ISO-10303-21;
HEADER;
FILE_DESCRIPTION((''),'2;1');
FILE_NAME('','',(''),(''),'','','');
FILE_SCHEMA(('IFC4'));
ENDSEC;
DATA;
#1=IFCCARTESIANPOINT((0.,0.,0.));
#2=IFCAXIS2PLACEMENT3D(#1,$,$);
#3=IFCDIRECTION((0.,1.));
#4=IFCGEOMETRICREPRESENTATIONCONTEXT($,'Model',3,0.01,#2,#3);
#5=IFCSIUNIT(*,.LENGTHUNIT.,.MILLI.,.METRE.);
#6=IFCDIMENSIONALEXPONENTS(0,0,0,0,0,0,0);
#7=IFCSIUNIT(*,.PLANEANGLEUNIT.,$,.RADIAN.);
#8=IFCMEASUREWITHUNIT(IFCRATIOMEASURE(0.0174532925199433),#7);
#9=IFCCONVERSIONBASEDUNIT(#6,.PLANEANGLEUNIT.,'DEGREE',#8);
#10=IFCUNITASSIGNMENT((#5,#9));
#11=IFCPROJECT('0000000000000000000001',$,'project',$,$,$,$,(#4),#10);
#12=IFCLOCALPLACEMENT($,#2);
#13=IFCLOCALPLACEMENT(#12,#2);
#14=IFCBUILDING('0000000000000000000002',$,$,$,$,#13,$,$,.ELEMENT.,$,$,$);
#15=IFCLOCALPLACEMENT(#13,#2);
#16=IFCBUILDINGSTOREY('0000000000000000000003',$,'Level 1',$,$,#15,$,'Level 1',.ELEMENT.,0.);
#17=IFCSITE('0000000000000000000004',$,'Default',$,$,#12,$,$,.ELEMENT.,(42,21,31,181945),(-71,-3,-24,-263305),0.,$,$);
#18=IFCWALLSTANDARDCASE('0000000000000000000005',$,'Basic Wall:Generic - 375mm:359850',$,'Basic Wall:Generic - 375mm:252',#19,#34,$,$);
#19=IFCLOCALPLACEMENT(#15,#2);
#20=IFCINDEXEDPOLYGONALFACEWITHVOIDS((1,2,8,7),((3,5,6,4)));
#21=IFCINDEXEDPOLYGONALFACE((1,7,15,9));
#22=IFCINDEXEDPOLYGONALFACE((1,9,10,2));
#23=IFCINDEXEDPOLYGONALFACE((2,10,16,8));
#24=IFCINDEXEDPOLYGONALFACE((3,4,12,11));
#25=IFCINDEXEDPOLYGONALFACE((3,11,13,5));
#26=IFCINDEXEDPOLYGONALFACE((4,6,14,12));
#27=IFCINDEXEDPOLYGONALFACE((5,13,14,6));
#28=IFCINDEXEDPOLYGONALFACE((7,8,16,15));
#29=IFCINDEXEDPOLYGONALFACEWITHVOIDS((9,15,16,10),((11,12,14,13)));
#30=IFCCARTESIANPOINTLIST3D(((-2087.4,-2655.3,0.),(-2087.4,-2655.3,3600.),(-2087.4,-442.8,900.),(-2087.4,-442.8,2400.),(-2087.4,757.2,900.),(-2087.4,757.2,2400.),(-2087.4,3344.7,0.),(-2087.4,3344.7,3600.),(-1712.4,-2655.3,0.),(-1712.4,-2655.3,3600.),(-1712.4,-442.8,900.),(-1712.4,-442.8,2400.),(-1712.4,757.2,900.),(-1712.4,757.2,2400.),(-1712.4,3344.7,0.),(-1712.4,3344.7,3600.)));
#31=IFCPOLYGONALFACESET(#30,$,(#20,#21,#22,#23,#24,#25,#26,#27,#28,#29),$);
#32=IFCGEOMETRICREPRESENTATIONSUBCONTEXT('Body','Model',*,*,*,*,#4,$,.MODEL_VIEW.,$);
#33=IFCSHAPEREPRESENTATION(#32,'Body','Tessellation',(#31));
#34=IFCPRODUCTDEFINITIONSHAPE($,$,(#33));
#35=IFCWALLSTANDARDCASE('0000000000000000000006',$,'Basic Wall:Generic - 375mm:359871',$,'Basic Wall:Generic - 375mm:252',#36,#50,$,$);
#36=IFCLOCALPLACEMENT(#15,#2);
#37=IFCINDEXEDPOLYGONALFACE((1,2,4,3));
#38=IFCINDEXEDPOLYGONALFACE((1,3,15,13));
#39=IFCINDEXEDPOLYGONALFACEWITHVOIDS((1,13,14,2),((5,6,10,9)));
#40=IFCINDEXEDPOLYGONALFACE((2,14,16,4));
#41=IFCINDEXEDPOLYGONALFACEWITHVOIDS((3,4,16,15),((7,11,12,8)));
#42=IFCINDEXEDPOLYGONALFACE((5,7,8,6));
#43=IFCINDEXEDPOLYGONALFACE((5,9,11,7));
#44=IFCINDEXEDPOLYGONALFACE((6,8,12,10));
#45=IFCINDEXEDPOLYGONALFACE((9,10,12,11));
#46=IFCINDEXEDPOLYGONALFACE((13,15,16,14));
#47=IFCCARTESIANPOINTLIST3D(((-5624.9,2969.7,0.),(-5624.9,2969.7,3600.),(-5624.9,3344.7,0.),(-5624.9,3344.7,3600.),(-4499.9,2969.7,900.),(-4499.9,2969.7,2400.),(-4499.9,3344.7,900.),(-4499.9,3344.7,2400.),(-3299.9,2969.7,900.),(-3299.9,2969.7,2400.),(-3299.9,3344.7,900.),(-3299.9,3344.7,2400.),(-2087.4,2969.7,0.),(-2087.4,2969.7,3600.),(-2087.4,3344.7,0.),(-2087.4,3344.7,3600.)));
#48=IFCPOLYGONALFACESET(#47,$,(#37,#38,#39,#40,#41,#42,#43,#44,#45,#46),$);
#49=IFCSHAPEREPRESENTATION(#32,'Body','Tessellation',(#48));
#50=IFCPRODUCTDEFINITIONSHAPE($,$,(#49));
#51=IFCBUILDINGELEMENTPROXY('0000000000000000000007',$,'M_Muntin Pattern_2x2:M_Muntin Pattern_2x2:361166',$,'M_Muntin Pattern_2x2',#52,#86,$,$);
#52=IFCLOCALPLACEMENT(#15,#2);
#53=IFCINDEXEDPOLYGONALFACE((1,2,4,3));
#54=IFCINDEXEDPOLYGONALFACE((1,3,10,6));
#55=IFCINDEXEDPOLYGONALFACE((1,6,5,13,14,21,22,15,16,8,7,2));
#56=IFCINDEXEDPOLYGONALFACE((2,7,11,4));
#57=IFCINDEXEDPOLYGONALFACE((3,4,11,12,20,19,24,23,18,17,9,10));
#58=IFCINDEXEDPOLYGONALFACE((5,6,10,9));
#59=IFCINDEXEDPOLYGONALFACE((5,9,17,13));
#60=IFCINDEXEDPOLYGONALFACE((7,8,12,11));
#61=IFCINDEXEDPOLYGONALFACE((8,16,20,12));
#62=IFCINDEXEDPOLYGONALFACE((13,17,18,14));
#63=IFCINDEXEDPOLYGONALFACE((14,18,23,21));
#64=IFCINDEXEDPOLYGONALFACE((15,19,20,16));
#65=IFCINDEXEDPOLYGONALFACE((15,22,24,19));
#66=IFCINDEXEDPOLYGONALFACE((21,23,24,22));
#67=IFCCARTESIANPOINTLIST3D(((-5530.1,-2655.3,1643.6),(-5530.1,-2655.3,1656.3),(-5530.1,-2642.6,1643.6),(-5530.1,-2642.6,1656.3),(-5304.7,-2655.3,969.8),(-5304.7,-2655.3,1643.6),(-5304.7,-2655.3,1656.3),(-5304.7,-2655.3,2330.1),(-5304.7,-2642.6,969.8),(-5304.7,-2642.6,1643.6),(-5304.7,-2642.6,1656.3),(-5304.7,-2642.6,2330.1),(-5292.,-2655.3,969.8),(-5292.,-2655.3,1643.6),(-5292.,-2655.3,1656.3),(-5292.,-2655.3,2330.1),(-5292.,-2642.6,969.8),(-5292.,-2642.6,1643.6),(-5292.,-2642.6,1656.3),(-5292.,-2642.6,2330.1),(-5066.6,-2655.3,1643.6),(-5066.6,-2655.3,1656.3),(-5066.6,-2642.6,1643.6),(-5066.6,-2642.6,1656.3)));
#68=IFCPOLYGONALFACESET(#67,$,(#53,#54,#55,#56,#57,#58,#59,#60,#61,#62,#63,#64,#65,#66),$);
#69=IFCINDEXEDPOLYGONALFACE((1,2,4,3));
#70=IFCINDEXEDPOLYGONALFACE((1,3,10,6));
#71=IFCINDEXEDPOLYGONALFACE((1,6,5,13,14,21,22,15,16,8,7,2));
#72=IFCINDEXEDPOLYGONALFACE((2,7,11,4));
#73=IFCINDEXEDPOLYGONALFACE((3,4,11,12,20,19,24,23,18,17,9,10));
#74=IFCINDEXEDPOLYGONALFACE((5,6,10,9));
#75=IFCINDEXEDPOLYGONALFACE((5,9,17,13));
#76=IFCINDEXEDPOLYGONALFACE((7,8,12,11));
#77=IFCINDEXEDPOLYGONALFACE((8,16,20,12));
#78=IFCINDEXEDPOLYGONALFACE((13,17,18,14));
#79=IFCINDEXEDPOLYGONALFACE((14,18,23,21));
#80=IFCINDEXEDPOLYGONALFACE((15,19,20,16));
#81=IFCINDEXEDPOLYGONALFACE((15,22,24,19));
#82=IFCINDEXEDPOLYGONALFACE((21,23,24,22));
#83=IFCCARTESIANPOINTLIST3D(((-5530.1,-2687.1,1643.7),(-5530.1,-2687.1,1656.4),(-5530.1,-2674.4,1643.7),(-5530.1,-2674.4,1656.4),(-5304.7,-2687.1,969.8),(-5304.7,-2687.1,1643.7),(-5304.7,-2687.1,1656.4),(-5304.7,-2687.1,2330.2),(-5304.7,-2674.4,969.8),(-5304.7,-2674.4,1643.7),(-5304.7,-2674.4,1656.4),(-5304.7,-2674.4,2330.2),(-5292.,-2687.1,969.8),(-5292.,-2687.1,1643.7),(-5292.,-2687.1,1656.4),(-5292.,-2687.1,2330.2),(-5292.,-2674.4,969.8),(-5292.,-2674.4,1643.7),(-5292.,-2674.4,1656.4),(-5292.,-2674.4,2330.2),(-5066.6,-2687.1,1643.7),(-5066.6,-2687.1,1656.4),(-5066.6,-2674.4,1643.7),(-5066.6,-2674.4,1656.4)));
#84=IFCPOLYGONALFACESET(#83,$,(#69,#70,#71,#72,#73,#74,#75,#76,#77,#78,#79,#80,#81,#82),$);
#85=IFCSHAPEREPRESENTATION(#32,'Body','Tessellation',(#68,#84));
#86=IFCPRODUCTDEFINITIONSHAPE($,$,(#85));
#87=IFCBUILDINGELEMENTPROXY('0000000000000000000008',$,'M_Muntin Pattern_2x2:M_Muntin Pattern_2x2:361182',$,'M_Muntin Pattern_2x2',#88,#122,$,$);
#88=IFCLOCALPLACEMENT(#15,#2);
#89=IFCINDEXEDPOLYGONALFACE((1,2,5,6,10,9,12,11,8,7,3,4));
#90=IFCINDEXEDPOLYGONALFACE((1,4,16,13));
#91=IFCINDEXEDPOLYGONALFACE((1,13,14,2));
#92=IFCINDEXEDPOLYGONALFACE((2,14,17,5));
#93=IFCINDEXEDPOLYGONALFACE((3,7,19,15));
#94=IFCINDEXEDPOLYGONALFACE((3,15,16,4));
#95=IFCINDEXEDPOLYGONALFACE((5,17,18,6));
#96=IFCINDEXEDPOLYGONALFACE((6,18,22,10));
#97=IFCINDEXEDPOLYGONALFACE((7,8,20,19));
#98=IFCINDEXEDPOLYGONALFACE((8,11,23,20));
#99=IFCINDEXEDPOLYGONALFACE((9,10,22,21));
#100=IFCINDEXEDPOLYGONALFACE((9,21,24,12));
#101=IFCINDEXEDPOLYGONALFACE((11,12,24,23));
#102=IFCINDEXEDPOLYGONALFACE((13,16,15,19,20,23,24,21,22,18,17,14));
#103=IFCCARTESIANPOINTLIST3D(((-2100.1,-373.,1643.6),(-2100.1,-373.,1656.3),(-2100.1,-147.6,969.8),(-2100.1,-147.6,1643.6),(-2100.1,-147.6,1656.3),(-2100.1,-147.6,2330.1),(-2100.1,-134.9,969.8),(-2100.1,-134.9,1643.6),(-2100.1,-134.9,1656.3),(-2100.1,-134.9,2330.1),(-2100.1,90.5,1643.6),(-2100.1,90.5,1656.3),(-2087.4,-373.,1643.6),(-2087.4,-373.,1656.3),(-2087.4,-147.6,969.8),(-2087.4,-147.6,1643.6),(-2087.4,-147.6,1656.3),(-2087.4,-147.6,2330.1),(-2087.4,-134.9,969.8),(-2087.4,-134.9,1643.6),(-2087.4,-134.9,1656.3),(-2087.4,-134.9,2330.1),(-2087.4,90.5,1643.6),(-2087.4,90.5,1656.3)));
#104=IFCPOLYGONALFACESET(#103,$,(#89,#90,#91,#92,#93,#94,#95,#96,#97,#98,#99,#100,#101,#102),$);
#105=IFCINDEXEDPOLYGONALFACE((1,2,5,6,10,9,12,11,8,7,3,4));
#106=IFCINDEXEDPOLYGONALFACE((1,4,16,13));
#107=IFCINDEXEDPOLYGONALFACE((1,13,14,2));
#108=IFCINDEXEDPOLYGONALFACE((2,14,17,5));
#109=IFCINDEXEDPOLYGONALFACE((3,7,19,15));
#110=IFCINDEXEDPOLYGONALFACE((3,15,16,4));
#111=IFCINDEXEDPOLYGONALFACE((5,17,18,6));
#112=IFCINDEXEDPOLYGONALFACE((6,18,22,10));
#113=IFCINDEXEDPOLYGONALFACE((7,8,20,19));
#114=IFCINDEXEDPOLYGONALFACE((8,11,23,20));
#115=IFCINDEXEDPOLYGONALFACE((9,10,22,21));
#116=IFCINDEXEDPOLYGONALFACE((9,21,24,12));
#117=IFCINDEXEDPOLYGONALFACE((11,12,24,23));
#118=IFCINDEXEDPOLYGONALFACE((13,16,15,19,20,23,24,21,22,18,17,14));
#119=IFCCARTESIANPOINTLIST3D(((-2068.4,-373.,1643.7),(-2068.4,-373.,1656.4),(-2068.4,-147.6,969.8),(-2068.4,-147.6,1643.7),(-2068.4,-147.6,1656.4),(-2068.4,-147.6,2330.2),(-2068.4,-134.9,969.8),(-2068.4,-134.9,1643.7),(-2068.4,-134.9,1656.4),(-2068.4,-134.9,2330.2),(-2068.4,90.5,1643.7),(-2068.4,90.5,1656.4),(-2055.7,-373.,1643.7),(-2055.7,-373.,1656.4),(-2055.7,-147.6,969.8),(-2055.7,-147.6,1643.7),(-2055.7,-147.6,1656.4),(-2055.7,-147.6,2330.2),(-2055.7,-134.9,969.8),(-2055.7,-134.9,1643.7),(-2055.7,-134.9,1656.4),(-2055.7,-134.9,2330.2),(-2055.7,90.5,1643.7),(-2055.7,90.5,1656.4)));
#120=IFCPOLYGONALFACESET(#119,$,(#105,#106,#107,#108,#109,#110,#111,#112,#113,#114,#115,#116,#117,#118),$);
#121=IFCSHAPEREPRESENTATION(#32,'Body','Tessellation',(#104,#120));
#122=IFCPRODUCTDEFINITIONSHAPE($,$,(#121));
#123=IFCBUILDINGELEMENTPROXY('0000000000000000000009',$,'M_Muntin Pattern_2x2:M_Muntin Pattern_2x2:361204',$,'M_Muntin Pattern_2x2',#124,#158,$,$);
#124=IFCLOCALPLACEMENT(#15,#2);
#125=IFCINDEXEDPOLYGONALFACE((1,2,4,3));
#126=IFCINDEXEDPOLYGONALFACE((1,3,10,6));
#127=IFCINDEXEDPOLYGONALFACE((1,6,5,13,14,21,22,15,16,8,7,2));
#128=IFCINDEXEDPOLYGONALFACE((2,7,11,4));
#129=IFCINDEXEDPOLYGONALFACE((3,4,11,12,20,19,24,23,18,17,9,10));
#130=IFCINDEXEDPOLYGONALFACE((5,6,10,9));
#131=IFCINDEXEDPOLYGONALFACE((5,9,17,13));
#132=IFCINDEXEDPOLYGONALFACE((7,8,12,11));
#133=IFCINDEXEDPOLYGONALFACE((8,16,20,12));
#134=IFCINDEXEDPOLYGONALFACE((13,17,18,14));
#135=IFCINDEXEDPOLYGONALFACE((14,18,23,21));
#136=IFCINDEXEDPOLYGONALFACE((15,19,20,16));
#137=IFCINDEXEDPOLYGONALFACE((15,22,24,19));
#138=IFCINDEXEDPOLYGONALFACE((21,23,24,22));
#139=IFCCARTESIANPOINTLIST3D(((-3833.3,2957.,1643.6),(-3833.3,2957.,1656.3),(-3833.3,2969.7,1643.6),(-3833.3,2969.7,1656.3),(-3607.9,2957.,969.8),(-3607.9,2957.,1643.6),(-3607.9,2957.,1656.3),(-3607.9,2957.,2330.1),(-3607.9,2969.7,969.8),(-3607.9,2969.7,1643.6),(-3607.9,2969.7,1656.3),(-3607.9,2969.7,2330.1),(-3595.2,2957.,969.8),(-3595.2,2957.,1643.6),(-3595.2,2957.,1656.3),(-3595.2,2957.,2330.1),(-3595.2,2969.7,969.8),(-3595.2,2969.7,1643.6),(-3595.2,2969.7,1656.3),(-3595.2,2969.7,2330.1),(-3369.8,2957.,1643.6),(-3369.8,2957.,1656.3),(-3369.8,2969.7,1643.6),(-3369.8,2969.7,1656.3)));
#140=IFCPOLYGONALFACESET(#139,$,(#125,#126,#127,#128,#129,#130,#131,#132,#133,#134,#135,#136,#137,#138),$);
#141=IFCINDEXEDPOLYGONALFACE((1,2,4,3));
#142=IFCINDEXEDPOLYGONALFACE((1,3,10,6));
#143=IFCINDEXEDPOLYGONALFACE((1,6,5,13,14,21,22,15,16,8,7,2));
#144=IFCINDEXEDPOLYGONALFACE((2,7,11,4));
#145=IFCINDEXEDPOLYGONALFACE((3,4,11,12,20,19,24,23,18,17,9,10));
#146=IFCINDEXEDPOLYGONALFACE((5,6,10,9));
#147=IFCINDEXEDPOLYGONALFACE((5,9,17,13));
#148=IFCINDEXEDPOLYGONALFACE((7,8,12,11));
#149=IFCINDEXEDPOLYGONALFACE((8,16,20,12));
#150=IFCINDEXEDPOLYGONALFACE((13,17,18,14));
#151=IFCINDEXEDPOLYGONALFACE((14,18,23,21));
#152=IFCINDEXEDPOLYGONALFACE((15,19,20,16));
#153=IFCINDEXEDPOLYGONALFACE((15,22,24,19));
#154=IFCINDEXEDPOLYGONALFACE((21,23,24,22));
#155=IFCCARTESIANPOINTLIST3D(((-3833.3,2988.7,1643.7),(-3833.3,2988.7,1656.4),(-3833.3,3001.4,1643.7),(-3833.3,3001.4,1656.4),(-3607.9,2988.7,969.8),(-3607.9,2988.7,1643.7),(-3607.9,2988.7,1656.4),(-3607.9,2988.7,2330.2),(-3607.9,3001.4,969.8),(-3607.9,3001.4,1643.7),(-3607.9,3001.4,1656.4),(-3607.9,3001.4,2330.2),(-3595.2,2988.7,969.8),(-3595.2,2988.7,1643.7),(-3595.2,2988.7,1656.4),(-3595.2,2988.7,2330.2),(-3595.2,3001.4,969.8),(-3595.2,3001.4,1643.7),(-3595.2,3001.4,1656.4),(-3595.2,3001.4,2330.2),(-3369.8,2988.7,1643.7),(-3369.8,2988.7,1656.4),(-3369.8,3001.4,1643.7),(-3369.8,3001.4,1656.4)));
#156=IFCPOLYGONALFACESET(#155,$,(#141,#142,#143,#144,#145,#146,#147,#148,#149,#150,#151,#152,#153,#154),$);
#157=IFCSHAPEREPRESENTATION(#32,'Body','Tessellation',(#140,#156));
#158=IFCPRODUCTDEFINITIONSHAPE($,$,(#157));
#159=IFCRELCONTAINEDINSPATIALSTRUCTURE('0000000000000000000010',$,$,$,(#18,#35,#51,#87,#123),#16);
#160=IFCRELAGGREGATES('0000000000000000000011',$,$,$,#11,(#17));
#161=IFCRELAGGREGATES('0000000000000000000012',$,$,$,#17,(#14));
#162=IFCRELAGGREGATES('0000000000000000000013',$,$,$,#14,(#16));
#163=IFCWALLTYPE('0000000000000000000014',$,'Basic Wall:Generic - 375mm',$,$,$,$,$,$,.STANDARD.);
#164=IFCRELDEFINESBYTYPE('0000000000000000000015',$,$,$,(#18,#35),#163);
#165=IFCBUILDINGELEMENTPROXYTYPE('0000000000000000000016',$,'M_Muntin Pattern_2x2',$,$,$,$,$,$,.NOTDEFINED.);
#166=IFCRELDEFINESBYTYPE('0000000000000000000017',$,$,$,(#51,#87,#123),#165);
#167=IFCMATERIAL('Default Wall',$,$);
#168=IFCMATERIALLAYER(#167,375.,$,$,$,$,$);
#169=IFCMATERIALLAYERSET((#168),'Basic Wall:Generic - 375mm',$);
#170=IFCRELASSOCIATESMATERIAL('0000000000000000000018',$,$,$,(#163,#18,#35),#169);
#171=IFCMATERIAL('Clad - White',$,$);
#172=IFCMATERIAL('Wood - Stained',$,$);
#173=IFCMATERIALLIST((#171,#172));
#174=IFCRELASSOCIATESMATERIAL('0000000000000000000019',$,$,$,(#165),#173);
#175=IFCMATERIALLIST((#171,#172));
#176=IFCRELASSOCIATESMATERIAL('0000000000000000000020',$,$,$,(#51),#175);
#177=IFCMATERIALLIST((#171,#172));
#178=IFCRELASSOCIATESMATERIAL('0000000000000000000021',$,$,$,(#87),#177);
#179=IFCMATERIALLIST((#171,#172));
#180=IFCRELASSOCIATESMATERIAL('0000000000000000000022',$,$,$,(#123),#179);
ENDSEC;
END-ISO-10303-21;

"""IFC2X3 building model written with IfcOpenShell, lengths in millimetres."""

from ifc_helpers import new_model, entity, si_unit, converted_unit, direction, frame, frame_2d, origin, place, context, subcontext, project, spatial, polyline, rectangle, outline, extrude, clip, bounded_halfspace, source, transform, mapped, material, material_list, layer, layer_set, layer_usage, type_object, type_shapes, element, save


model = new_model("IFC2X3")

# Units and contexts
model_context = context("Model", 3, precision=0.01, world=origin(), true_north=direction((0.0, 1.0)))
body_context = subcontext(model_context, "Body", "Model", "MODEL_VIEW")
ifc_project = project(units=[si_unit("LENGTHUNIT", "METRE", prefix="MILLI"), converted_unit("PLANEANGLEUNIT", "DEGREE", entity("IfcRatioMeasure", 0.0174532925199433), si_unit("PLANEANGLEUNIT", "RADIAN"), dimensions=[0, 0, 0, 0, 0, 0, 0])], contexts=[model_context])

# Site, building, storey
site_placement = place(None, origin())
site = spatial("IfcSite", under=ifc_project, at=site_placement, Name="Default", CompositionType="ELEMENT", RefLatitude=(42, 21, 31, 181945), RefLongitude=(-71, -3, -24, -263305), RefElevation=0.0)
building_placement = place(site_placement, origin())
building = spatial("IfcBuilding", under=site, at=building_placement, CompositionType="ELEMENT")
storey_placement = place(building_placement, origin())
storey = spatial("IfcBuildingStorey", under=building, at=storey_placement, Name="Level 1", LongName="Level 1", CompositionType="ELEMENT", Elevation=0.0)

# Walls, openings
ifc_material_1 = material(Name="Default Wall")
ifc_layer = layer(ifc_material_1, 375.0)
ifc_layer_set = layer_set([ifc_layer], Name="Basic Wall:Generic - 375mm")
ifc_layer_usage_1 = layer_usage(ifc_layer_set, "AXIS2", "NEGATIVE", 187.5)
wall_type = type_object("IfcWallType", Name="Basic Wall:Generic - 375mm", PredefinedType="STANDARD", material=ifc_layer_set)
wall_1_placement = place(storey_placement, frame((-1899.9, -2655.3, 0.0), z_axis=(0.0, 0.0, 1.0), x_axis=(0.0, 1.0, 0.0)))
wall_1 = element("IfcWallStandardCase", 1, at=wall_1_placement, inside=storey, type_object=wall_type, material=ifc_layer_usage_1, Name="Basic Wall:Generic - 375mm:359850", ObjectType="Basic Wall:Generic - 375mm:252", context=body_context, shape_type="Clipping", body=[
    clip(extrude(rectangle(XDim=6000.0, YDim=375.0, at=frame_2d((3000.0, 0.0), x_axis=(-1.0, 0.0))), origin(), (0.0, 0.0, 1.0), 3600.0), bounded_halfspace(frame((0.0, -187.5, 3600.0), z_axis=(0.0, 0.0, -1.0), x_axis=(0.0, -1.0, 0.0)), True, frame((0.0, -187.5, 3600.0)), polyline([(0.0, 0.0), (6000.0, 0.0), (6000.0, 375.0), (5625.0, 375.0), (0.0, 375.0), (0.0, 0.0)]))),
])
opening_1_placement = place(wall_1_placement, frame((2212.5, -187.5, 900.0)))
element("IfcOpeningElement", 2, at=opening_1_placement, cuts=wall_1, ObjectType="Opening", context=body_context, shape_type="SweptSolid", body=[
    extrude(rectangle(XDim=1500.0, YDim=1200.0, at=frame_2d((750.0, 600.0), x_axis=(-1.0, 0.0))), frame((0.0, 0.0, 0.0), z_axis=(0.0, 1.0, 0.0), x_axis=(0.0, 0.0, 1.0)), (0.0, 0.0, 1.0), 375.0),
])
ifc_layer_usage_2 = layer_usage(ifc_layer_set, "AXIS2", "NEGATIVE", 187.5)
wall_2_placement = place(storey_placement, frame((-2087.4, 3157.2, 0.0), z_axis=(0.0, 0.0, 1.0), x_axis=(-1.0, 0.0, 0.0)))
wall_2 = element("IfcWallStandardCase", 3, at=wall_2_placement, inside=storey, type_object=wall_type, material=ifc_layer_usage_2, Name="Basic Wall:Generic - 375mm:359871", ObjectType="Basic Wall:Generic - 375mm:252", context=body_context, shape_type="Clipping", body=[
    clip(extrude(rectangle(XDim=3537.5, YDim=375.0, at=frame_2d((1768.8, 0.0), x_axis=(-1.0, 0.0))), origin(), (0.0, 0.0, 1.0), 3600.0), bounded_halfspace(frame((0.0, -187.5, 3600.0), z_axis=(0.0, 0.0, -1.0), x_axis=(-1.0, 0.0, 0.0)), True, frame((0.0, -187.5, 3600.0)), polyline([(0.0, 0.0), (3537.5, 0.0), (3537.5, 375.0), (0.0, 375.0), (0.0, 0.0)]))),
])
opening_2_placement = place(wall_2_placement, frame((1212.5, -187.5, 900.0)))
element("IfcOpeningElement", 4, at=opening_2_placement, cuts=wall_2, ObjectType="Opening", context=body_context, shape_type="SweptSolid", body=[
    extrude(rectangle(XDim=1500.0, YDim=1200.0, at=frame_2d((750.0, 600.0), x_axis=(-1.0, 0.0))), frame((0.0, 0.0, 0.0), z_axis=(0.0, 1.0, 0.0), x_axis=(0.0, 0.0, 1.0)), (0.0, 0.0, 1.0), 375.0),
])

# Building element proxies
ifc_material_2 = material(Name="Clad - White")
ifc_material_3 = material(Name="Wood - Stained")
ifc_material_list_1 = material_list([ifc_material_2, ifc_material_3])
ifc_material_list_2 = material_list([ifc_material_2, ifc_material_3])
building_element_proxy_type_1 = type_object("IfcBuildingElementProxyType", Name="M_Muntin Pattern_2x2", PredefinedType="NOTDEFINED", material=ifc_material_list_2)
shared_shape_1 = source(origin(), body_context, "Body", "SweptSolid", [
    extrude(outline(polyline([(6.4, -6.4), (680.1, -6.4), (680.1, 6.3), (6.4, 6.3), (6.4, 231.7), (-6.3, 231.7), (-6.3, 6.3), (-680.2, 6.3), (-680.2, -6.4), (-6.3, -6.4), (-6.3, -231.7), (6.4, -231.7), (6.4, -6.4)])), frame((0.0, 9.5, 680.1), z_axis=(0.0, 1.0, 0.0), x_axis=(0.0, 0.0, 1.0)), (0.0, 0.0, 1.0), 12.7),
    extrude(outline(polyline([(6.4, -6.4), (680.2, -6.4), (680.2, 6.3), (6.4, 6.3), (6.4, 231.7), (-6.3, 231.7), (-6.3, 6.3), (-680.2, 6.3), (-680.2, -6.4), (-6.3, -6.4), (-6.3, -231.7), (6.4, -231.7), (6.4, -6.4)])), frame((0.0, -22.2, 680.2), z_axis=(0.0, 1.0, 0.0), x_axis=(0.0, 0.0, 1.0)), (0.0, 0.0, 1.0), 12.7),
])
type_shapes(building_element_proxy_type_1, [shared_shape_1])
proxy_1_placement = place(storey_placement, frame((-5298.4, -2664.9, 969.8)))
element("IfcBuildingElementProxy", 5, at=proxy_1_placement, inside=storey, type_object=building_element_proxy_type_1, material=ifc_material_list_1, Name="M_Muntin Pattern_2x2:M_Muntin Pattern_2x2:361166", ObjectType="M_Muntin Pattern_2x2", context=body_context, shape_type="MappedRepresentation", body=[
    mapped(shared_shape_1, transform((0.0, 0.0, 0.0), scale=1.0)),
])
ifc_material_list_3 = material_list([ifc_material_2, ifc_material_3])
proxy_2_placement = place(storey_placement, frame((-2077.9, -141.3, 969.8), z_axis=(0.0, 0.0, 1.0), x_axis=(0.0, 1.0, 0.0)))
element("IfcBuildingElementProxy", 6, at=proxy_2_placement, inside=storey, type_object=building_element_proxy_type_1, material=ifc_material_list_3, Name="M_Muntin Pattern_2x2:M_Muntin Pattern_2x2:361182", ObjectType="M_Muntin Pattern_2x2", context=body_context, shape_type="MappedRepresentation", body=[
    mapped(shared_shape_1, transform((0.0, 0.0, 0.0), scale=1.0)),
])
ifc_material_list_4 = material_list([ifc_material_2, ifc_material_3])
proxy_3_placement = place(storey_placement, frame((-3601.5, 2979.2, 969.8), z_axis=(0.0, 0.0, 1.0), x_axis=(-1.0, 0.0, 0.0)))
element("IfcBuildingElementProxy", 7, at=proxy_3_placement, inside=storey, type_object=building_element_proxy_type_1, material=ifc_material_list_4, Name="M_Muntin Pattern_2x2:M_Muntin Pattern_2x2:361204", ObjectType="M_Muntin Pattern_2x2", context=body_context, shape_type="MappedRepresentation", body=[
    mapped(shared_shape_1, transform((0.0, 0.0, 0.0), scale=1.0)),
])

save(model, "model.ifc")
